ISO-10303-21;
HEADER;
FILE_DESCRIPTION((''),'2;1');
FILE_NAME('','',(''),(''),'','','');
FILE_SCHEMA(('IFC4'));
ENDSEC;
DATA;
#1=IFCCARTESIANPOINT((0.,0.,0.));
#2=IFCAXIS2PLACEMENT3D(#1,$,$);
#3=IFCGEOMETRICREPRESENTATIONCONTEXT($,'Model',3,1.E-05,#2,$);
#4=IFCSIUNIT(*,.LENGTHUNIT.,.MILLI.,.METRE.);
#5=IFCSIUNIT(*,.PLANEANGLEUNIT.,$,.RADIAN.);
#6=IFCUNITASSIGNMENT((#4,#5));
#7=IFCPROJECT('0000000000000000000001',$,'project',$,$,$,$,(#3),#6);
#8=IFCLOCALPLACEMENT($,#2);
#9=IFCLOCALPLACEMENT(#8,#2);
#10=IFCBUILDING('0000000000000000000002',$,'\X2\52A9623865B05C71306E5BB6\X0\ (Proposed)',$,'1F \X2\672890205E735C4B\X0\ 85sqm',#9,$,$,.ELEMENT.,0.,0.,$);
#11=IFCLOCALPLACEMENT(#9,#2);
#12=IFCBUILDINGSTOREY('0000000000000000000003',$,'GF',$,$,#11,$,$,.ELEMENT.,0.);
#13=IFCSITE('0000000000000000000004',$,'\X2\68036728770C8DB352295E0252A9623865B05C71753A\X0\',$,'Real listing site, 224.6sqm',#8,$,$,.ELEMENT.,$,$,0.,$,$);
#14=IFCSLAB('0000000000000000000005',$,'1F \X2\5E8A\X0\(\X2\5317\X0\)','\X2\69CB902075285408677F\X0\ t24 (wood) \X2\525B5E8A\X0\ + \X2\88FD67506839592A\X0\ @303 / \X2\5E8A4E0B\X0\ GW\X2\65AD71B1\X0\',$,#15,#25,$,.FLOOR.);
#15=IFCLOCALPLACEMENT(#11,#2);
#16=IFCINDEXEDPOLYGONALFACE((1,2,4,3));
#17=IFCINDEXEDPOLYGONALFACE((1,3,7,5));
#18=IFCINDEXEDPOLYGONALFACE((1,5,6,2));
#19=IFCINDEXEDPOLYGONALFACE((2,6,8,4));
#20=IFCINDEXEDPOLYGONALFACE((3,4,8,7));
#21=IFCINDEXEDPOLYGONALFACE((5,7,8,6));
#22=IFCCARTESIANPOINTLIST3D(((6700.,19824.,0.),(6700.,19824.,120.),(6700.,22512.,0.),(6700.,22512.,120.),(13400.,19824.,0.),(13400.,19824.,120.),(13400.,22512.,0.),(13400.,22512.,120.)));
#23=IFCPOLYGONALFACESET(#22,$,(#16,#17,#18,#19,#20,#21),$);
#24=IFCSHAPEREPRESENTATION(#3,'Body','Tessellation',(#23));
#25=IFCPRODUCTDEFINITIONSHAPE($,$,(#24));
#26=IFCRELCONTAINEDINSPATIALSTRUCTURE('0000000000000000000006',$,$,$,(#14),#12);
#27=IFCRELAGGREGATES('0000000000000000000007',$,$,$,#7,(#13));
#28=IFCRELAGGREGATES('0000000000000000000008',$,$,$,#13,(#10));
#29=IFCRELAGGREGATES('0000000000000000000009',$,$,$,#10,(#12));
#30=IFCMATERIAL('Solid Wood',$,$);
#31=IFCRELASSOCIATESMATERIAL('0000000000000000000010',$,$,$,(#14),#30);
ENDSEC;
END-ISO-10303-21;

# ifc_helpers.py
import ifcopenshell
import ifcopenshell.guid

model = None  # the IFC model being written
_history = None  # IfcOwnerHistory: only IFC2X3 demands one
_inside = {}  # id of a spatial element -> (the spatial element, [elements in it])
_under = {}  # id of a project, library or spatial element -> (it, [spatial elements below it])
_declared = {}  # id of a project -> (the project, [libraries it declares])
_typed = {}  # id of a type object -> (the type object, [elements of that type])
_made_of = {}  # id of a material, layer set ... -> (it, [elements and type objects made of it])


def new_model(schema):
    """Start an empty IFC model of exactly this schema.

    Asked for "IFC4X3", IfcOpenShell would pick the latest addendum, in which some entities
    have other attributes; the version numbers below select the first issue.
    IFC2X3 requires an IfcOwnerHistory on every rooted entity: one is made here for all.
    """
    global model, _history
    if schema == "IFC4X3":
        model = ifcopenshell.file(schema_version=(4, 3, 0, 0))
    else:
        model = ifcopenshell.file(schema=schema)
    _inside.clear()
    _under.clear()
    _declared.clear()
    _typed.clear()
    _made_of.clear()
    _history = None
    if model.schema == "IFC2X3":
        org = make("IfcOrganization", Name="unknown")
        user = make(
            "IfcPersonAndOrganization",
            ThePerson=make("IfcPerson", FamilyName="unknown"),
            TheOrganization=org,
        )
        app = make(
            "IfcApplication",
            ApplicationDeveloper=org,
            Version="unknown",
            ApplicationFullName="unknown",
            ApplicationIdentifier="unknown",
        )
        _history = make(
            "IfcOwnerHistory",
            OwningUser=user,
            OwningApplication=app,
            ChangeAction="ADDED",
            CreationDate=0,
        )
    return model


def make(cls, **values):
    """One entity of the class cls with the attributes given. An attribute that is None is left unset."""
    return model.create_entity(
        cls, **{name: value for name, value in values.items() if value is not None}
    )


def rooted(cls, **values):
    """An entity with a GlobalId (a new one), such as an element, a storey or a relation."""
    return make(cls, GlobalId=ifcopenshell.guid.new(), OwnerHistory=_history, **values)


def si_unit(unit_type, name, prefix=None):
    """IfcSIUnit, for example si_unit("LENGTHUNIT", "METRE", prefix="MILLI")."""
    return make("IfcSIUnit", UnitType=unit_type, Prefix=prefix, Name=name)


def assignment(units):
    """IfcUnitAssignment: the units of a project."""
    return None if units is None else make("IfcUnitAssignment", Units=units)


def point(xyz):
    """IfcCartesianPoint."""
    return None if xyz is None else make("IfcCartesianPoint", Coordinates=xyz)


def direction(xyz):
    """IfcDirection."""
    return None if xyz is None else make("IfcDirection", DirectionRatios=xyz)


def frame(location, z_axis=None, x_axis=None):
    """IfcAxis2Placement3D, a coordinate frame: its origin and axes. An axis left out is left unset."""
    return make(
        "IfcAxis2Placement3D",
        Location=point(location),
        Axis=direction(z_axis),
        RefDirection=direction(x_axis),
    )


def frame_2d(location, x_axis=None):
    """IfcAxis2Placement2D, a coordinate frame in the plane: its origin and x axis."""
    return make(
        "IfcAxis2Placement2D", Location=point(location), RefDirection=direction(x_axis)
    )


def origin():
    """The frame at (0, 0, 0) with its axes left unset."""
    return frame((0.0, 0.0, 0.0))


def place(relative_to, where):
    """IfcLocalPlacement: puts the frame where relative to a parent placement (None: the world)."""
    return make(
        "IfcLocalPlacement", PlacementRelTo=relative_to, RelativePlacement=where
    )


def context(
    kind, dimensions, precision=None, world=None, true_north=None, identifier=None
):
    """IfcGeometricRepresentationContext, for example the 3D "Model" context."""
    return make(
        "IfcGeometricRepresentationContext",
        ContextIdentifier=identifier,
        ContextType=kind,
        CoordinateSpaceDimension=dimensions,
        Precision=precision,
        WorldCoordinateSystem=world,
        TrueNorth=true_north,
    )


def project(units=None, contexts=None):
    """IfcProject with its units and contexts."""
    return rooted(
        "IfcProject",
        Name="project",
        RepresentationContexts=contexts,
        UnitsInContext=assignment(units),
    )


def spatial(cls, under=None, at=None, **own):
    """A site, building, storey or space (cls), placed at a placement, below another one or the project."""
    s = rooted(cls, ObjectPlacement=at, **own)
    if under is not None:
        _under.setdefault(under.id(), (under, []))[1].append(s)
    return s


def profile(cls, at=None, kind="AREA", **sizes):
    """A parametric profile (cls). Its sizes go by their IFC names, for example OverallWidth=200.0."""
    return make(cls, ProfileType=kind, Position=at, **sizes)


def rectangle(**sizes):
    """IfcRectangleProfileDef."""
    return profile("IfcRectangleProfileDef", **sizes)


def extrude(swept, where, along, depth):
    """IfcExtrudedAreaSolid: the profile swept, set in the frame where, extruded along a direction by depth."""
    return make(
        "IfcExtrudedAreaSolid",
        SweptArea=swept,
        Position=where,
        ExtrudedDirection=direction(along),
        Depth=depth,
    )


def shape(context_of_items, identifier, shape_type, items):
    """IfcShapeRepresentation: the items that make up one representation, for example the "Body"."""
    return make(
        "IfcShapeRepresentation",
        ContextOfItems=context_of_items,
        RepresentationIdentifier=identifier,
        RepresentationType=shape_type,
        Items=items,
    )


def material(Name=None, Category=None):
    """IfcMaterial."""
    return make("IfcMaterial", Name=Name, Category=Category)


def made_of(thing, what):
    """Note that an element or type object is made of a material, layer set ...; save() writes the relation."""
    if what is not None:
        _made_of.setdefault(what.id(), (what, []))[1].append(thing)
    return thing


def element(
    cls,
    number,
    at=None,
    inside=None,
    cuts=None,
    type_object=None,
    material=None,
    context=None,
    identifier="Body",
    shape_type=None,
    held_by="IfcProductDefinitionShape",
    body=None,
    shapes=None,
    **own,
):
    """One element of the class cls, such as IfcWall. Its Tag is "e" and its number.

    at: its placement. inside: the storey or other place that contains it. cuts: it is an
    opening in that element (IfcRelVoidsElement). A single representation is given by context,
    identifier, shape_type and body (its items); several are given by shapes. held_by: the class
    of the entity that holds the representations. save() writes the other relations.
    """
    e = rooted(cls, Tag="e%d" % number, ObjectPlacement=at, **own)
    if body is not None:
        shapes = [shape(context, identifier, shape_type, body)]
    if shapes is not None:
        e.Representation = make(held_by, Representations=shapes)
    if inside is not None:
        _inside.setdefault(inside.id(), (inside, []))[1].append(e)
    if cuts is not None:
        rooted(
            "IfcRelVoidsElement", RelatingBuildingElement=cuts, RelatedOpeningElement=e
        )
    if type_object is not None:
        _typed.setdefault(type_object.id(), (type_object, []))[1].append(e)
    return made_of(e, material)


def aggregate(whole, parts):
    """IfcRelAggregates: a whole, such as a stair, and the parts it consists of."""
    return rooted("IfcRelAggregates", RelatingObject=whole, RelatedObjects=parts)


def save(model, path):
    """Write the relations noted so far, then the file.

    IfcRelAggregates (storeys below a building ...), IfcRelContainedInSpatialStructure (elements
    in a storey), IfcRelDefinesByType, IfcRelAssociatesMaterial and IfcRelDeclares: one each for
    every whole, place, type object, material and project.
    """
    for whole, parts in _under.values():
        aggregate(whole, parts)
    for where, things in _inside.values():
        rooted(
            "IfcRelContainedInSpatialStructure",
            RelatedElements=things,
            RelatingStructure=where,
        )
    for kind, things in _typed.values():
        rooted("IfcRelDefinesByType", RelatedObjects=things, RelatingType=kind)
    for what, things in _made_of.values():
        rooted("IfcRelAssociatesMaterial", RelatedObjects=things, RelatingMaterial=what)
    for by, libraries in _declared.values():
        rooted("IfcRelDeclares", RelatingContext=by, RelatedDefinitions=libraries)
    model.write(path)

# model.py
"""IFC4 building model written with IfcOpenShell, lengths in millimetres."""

from ifc_helpers import new_model, si_unit, frame, frame_2d, origin, place, context, project, spatial, rectangle, extrude, material, element, save


model = new_model("IFC4")

# Units and contexts
model_context = context("Model", 3, precision=1e-05, world=origin())
ifc_project = project(units=[si_unit("LENGTHUNIT", "METRE", prefix="MILLI"), si_unit("PLANEANGLEUNIT", "RADIAN")], contexts=[model_context])

# Site, building, storey
site_placement = place(None, origin())
site = spatial("IfcSite", under=ifc_project, at=site_placement, Name="栃木県足利市助戸新山町", ObjectType="Real listing site, 224.6sqm", CompositionType="ELEMENT", RefElevation=0.0)
building_placement = place(site_placement, origin())
building = spatial("IfcBuilding", under=site, at=building_placement, Name="助戸新山の家 (Proposed)", ObjectType="1F 木造平屋 85sqm", CompositionType="ELEMENT", ElevationOfRefHeight=0.0, ElevationOfTerrain=0.0)
storey_placement = place(building_placement, origin())
storey = spatial("IfcBuildingStorey", under=building, at=storey_placement, Name="GF", CompositionType="ELEMENT", Elevation=0.0)

# Slab
ifc_material_1 = material(Name="Solid Wood")
slab_1_placement = place(storey_placement, frame((3350.0, 9912.0, 0.0)))
element("IfcSlab", 1, at=slab_1_placement, inside=storey, material=ifc_material_1, Name="1F 床(北)", Description="構造用合板 t24 (wood) 剛床 + 製材根太 @303 / 床下 GW断熱", PredefinedType="FLOOR", context=model_context, shape_type="SweptSolid", body=[
    extrude(rectangle(XDim=6700.0, YDim=2688.0, at=frame_2d((3350.0, 1344.0))), frame((3350.0, 9912.0, 0.0)), (0.0, 0.0, 1.0), 120.0),
])

save(model, "model.ifc")
